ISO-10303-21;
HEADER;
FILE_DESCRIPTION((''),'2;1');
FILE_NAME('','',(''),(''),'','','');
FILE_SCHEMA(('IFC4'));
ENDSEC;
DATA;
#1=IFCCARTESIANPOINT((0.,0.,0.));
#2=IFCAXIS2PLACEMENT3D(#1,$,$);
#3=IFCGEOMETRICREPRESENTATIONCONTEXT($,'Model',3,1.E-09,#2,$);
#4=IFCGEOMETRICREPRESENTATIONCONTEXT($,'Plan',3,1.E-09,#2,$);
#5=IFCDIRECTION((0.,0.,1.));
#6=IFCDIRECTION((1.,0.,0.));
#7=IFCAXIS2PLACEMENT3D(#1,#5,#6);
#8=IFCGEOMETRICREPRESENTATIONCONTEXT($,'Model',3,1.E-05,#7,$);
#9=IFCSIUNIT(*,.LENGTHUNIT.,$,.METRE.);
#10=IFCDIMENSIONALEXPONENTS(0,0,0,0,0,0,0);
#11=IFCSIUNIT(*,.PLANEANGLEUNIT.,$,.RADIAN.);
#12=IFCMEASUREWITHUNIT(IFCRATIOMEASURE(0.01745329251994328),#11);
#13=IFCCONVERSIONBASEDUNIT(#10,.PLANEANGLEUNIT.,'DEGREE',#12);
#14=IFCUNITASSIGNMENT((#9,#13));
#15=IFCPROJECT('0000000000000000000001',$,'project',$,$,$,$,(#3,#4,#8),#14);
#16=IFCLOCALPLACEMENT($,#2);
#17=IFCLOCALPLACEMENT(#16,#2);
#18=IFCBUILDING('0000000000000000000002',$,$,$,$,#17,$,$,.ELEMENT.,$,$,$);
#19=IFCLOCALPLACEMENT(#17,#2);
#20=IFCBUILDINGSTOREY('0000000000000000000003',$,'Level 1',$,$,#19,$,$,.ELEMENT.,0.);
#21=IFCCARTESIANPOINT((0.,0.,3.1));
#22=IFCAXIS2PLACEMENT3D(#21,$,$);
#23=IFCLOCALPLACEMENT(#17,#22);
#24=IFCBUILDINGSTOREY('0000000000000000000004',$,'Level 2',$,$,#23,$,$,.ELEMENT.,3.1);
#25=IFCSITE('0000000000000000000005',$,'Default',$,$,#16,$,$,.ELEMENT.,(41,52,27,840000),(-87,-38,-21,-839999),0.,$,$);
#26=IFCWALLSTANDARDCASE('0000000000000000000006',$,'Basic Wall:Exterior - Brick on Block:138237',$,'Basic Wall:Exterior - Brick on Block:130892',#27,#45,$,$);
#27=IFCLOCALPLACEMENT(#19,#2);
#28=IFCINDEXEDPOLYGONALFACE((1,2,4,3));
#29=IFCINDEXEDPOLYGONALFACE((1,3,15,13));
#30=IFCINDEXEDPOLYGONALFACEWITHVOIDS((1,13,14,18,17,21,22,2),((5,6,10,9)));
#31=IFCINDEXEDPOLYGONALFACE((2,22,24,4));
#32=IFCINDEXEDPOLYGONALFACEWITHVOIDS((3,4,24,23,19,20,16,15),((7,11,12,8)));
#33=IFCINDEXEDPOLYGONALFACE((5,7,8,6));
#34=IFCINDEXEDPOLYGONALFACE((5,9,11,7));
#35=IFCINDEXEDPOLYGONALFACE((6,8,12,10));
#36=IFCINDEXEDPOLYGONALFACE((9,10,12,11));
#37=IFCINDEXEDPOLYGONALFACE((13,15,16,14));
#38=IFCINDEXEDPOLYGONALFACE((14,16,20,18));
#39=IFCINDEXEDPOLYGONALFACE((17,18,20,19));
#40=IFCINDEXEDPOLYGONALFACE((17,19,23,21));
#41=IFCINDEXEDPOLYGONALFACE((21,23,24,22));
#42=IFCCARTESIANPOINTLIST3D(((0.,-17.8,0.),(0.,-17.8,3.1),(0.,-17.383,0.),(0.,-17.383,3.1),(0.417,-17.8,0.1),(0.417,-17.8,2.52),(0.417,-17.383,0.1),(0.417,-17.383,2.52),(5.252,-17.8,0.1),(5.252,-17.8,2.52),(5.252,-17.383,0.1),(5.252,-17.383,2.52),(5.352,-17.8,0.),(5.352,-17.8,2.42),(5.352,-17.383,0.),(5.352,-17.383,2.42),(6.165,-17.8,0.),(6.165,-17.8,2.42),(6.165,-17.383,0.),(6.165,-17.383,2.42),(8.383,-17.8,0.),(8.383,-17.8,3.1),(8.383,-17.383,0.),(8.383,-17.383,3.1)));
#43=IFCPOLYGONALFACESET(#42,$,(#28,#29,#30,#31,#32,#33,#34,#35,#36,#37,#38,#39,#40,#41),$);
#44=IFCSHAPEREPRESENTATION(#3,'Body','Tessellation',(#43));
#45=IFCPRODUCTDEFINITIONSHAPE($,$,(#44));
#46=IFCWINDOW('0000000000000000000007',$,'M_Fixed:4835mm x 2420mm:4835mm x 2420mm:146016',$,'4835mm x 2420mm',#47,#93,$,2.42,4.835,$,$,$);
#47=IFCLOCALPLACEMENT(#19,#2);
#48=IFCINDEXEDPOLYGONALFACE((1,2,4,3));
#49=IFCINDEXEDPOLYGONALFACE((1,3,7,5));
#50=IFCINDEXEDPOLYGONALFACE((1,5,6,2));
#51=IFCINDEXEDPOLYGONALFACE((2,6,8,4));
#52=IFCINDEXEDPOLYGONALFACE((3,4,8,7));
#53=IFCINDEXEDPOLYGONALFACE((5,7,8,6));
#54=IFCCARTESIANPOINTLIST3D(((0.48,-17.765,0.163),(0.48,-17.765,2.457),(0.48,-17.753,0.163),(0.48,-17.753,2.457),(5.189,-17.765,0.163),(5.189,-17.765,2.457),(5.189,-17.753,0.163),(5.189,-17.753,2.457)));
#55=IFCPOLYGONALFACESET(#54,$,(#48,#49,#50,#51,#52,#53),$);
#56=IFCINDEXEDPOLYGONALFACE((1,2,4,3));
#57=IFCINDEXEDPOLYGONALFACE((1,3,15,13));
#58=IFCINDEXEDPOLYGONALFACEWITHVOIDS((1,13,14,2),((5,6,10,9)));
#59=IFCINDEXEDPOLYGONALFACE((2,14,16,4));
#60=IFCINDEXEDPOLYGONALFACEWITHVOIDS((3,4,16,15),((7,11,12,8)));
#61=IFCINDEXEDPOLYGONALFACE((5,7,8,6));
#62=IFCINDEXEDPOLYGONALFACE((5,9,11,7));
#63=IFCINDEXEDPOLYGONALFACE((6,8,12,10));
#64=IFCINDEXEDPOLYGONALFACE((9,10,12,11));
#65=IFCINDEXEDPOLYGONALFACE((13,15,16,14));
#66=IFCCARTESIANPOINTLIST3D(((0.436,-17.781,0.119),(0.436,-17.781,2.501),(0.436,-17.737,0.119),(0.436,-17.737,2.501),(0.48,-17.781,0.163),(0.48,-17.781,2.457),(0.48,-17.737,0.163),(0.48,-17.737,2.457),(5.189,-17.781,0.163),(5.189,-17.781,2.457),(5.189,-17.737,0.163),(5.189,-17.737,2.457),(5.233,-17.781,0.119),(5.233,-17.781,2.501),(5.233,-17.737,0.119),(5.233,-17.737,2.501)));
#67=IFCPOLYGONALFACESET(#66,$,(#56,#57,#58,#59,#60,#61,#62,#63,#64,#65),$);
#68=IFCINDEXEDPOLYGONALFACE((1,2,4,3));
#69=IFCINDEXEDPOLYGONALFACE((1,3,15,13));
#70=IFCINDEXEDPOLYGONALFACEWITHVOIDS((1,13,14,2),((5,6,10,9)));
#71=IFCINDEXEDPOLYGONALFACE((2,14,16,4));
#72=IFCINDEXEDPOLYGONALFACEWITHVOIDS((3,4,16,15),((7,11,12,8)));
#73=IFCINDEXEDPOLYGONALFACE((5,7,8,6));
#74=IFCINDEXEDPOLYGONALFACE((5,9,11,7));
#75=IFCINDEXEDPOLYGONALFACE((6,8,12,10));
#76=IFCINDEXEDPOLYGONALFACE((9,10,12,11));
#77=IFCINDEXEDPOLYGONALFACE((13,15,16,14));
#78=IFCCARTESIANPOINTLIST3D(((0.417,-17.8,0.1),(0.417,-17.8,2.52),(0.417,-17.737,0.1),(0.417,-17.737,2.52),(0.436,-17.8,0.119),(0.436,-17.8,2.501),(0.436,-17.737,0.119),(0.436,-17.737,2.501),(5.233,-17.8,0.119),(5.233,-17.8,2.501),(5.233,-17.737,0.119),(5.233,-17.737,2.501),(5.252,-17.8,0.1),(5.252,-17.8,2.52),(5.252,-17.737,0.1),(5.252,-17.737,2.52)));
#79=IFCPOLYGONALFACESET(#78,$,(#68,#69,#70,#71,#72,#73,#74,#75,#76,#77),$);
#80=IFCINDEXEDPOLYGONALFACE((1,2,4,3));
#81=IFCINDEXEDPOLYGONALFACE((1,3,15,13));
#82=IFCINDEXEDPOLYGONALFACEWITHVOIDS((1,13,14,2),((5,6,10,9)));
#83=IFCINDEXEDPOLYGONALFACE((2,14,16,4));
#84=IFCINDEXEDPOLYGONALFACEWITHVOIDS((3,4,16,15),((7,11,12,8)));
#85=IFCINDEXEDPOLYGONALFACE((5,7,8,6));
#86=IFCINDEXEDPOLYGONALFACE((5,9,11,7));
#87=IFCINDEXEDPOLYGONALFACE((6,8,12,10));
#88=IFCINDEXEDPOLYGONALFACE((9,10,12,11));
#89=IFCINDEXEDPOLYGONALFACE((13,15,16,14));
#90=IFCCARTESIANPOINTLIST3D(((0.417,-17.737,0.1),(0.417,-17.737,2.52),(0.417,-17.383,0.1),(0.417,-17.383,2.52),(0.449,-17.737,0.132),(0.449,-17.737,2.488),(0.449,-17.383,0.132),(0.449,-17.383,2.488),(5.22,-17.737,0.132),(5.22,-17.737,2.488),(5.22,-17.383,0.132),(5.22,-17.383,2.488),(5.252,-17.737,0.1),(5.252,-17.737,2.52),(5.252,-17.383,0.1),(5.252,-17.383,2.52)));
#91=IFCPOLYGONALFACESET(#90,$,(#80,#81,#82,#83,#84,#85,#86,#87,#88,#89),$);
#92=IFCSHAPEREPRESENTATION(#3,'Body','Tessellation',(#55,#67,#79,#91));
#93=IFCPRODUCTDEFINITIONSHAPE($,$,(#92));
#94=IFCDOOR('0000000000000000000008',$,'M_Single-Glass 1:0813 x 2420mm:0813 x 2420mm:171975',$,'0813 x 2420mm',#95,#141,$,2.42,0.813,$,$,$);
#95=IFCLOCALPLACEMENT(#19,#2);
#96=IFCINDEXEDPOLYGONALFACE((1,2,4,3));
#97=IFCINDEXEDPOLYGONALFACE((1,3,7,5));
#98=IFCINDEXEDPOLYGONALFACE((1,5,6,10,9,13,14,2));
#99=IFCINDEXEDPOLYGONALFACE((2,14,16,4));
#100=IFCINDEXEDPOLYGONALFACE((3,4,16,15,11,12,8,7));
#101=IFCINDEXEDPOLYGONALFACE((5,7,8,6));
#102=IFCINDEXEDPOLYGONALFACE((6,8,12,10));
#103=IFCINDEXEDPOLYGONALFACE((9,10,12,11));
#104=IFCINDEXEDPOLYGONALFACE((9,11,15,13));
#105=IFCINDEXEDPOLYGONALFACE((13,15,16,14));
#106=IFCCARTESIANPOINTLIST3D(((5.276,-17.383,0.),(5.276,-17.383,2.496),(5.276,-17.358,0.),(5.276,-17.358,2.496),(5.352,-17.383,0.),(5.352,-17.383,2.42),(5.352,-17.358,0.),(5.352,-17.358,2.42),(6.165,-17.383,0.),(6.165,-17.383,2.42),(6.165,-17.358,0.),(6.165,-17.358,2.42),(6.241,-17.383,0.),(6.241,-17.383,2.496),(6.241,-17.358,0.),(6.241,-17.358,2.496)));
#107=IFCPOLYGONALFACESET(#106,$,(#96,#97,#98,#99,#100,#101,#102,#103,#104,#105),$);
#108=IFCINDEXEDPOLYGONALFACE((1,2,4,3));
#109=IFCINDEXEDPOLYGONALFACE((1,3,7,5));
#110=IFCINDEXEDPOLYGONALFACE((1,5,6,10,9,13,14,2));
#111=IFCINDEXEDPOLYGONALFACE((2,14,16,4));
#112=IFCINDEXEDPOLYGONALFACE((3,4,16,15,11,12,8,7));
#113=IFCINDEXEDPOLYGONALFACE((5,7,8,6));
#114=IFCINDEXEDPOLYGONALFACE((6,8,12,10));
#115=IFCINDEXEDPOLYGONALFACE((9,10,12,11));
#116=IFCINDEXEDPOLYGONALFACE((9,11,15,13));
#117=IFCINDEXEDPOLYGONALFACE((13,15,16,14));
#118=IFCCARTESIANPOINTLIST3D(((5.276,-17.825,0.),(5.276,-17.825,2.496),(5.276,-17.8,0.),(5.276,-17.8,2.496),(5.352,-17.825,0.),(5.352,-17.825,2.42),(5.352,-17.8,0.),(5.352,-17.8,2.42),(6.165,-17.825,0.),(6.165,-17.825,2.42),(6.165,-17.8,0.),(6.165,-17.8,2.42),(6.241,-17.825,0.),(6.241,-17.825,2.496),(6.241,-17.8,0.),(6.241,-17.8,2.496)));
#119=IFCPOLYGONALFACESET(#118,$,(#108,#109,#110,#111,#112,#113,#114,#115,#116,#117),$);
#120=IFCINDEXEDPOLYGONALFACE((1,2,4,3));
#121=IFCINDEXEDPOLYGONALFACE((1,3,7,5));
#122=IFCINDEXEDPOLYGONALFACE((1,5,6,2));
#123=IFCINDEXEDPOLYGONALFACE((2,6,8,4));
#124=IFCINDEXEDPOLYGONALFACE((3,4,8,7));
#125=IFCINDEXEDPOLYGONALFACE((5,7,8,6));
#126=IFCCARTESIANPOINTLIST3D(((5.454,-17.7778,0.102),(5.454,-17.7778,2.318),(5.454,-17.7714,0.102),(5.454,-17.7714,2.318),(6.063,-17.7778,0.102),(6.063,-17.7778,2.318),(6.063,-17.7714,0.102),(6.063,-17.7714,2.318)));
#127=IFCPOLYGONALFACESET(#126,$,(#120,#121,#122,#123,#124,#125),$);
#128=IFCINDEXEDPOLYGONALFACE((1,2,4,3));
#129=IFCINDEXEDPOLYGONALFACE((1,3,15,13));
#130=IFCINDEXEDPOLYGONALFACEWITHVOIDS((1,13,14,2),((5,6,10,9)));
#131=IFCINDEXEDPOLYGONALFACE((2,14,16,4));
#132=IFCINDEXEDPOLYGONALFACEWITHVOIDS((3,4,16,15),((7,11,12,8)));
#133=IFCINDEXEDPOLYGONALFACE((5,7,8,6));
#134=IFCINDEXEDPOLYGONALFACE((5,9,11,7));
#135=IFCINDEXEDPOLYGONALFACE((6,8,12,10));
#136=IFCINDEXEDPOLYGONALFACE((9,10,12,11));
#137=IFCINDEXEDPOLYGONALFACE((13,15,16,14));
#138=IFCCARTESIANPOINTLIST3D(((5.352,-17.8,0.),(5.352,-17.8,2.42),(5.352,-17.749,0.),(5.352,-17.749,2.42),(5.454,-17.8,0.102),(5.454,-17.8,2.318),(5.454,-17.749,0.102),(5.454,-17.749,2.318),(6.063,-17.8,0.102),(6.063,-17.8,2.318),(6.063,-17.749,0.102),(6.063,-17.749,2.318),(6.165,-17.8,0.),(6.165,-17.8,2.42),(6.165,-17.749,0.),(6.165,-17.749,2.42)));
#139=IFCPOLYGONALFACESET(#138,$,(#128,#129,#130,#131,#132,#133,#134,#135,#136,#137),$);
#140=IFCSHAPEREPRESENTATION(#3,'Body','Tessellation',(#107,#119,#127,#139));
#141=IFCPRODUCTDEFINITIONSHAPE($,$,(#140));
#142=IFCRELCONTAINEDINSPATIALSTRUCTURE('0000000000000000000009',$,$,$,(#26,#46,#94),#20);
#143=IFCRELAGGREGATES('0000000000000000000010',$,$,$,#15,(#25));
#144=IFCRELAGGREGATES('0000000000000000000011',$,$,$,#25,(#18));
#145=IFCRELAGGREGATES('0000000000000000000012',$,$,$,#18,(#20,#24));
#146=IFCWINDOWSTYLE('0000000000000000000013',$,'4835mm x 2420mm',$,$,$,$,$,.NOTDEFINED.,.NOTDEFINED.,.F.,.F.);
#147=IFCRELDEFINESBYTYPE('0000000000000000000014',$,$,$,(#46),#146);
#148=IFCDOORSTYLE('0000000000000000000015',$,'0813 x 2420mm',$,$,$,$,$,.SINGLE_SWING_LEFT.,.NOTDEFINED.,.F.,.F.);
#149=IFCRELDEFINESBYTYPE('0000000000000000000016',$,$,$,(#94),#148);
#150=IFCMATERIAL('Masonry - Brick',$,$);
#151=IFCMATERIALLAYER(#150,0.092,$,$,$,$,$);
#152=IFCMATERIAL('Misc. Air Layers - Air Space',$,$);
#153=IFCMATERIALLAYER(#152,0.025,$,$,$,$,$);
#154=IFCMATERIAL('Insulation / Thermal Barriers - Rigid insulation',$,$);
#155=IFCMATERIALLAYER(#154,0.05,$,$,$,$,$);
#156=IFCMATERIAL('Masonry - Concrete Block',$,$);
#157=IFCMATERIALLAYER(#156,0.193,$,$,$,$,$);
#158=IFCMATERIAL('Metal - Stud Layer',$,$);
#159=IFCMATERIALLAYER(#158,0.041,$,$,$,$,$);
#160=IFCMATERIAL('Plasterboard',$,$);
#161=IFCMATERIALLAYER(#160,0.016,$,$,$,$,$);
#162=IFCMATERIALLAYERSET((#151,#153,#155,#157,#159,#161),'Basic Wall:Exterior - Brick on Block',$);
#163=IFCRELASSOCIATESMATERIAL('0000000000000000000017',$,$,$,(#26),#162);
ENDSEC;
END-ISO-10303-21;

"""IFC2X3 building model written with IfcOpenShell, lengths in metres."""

from ifc_helpers import new_model, entity, si_unit, converted_unit, frame, frame_2d, origin, origin_with_axes, origin_2d_with_axis, place, context, project, spatial, polyline, rectangle, outline, extrude, source, transform, mapped, material, layer, layer_set, layer_usage, type_object, type_shapes, element, fill, save


model = new_model("IFC2X3")

# Units and contexts
model_context_1 = context("Model", 3, precision=1e-09, world=origin())
plan_context = context("Plan", 3, precision=1e-09, world=origin())
model_context_2 = context("Model", 3, precision=1e-05, world=origin_with_axes())
ifc_project = project(units=[si_unit("LENGTHUNIT", "METRE"), converted_unit("PLANEANGLEUNIT", "DEGREE", entity("IfcRatioMeasure", 0.01745329251994328), si_unit("PLANEANGLEUNIT", "RADIAN"), dimensions=[0, 0, 0, 0, 0, 0, 0])], contexts=[model_context_1, plan_context, model_context_2])

# Site, building, storey
site_placement = place(None, origin())
site = spatial("IfcSite", under=ifc_project, at=site_placement, Name="Default", CompositionType="ELEMENT", RefLatitude=(41, 52, 27, 840000), RefLongitude=(-87, -38, -21, -839999), RefElevation=0.0)
building_placement = place(site_placement, origin())
building = spatial("IfcBuilding", under=site, at=building_placement, CompositionType="ELEMENT")
storey_1_placement = place(building_placement, origin())
storey_1 = spatial("IfcBuildingStorey", under=building, at=storey_1_placement, Name="Level 1", CompositionType="ELEMENT", Elevation=0.0)

# Wall, openings, window, door
ifc_material_1 = material(Name="Masonry - Brick")
ifc_layer_1 = layer(ifc_material_1, 0.092)
ifc_material_2 = material(Name="Misc. Air Layers - Air Space")
ifc_layer_2 = layer(ifc_material_2, 0.025)
ifc_material_3 = material(Name="Insulation / Thermal Barriers - Rigid insulation")
ifc_layer_3 = layer(ifc_material_3, 0.05)
ifc_material_4 = material(Name="Masonry - Concrete Block")
ifc_layer_4 = layer(ifc_material_4, 0.193)
ifc_material_5 = material(Name="Metal - Stud Layer")
ifc_layer_5 = layer(ifc_material_5, 0.041)
ifc_material_6 = material(Name="Plasterboard")
ifc_layer_6 = layer(ifc_material_6, 0.016)
ifc_layer_set_1 = layer_set([ifc_layer_1, ifc_layer_2, ifc_layer_3, ifc_layer_4, ifc_layer_5, ifc_layer_6], Name="Basic Wall:Exterior - Brick on Block")
ifc_layer_usage_1 = layer_usage(ifc_layer_set_1, "AXIS2", "NEGATIVE", 0.2085)
wall_1_placement = place(storey_1_placement, frame((8.383, -17.5915, 0.0), z_axis=(0.0, 0.0, 1.0), x_axis=(-1.0, 0.0, 0.0)))
wall_1 = element("IfcWallStandardCase", 1, at=wall_1_placement, inside=storey_1, material=ifc_layer_usage_1, Name="Basic Wall:Exterior - Brick on Block:138237", ObjectType="Basic Wall:Exterior - Brick on Block:130892", context=model_context_1, shape_type="SweptSolid", body=[
    extrude(rectangle(XDim=8.383, YDim=0.417, at=frame_2d((4.1915, 0.0), x_axis=(-1.0, 0.0))), origin(), (0.0, 0.0, 1.0), 3.1),
])
opening_1_placement = place(wall_1_placement, frame((3.131, -0.2085, 0.1)))
opening_1 = element("IfcOpeningElement", 2, at=opening_1_placement, cuts=wall_1, ObjectType="Opening", context=model_context_1, shape_type="SweptSolid", body=[
    extrude(rectangle(XDim=2.42, YDim=4.835, at=frame_2d((1.21, 2.4175), x_axis=(1.0, 0.0))), frame((0.0, 0.0, 0.0), z_axis=(0.0, 1.0, 0.0), x_axis=(0.0, 0.0, 1.0)), (0.0, 0.0, 1.0), 0.417),
])
opening_2_placement = place(wall_1_placement, frame((2.218, -0.2085, 0.0)))
opening_2 = element("IfcOpeningElement", 3, at=opening_2_placement, cuts=wall_1, ObjectType="Opening", context=model_context_1, shape_type="SweptSolid", body=[
    extrude(rectangle(XDim=0.813, YDim=2.42, at=frame_2d((1.21, 0.4065), x_axis=(0.0, -1.0))), frame((0.0, 0.0, 0.0), z_axis=(0.0, 1.0, 0.0), x_axis=(0.0, 0.0, 1.0)), (0.0, 0.0, 1.0), 0.417),
])
window_style_1 = type_object("IfcWindowStyle", Name="4835mm x 2420mm", ConstructionType="NOTDEFINED", OperationType="NOTDEFINED", ParameterTakesPrecedence=False, Sizeable=False)
shared_shape_1 = source(origin(), model_context_1, "Body", "SweptSolid", [
    extrude(rectangle(XDim=0.012, YDim=4.709, at=origin_2d_with_axis()), frame((2.4175, 0.376, 0.063), z_axis=(0.0, 0.0, 1.0), x_axis=(0.0, -1.0, 0.0)), (0.0, 0.0, 1.0), 2.294),
    extrude(outline(polyline([(-2.3985, -1.191), (2.3985, -1.191), (2.3985, 1.191), (-2.3985, 1.191), (-2.3985, -1.191)]), holes=[polyline([(-2.3545, -1.147), (-2.3545, 1.147), (2.3545, 1.147), (2.3545, -1.147), (-2.3545, -1.147)])]), frame((2.4175, 0.354, 1.21), z_axis=(0.0, 1.0, 0.0), x_axis=(1.0, 0.0, 0.0)), (0.0, 0.0, 1.0), 0.044),
    extrude(outline(polyline([(-2.4175, -1.21), (2.4175, -1.21), (2.4175, 1.21), (-2.4175, 1.21), (-2.4175, -1.21)]), holes=[polyline([(-2.3985, -1.191), (-2.3985, 1.191), (2.3985, 1.191), (2.3985, -1.191), (-2.3985, -1.191)])]), frame((2.4175, 0.354, 1.21), z_axis=(0.0, 1.0, 0.0), x_axis=(1.0, 0.0, 0.0)), (0.0, 0.0, 1.0), 0.063),
    extrude(outline(polyline([(-2.4175, -1.21), (2.4175, -1.21), (2.4175, 1.21), (-2.4175, 1.21), (-2.4175, -1.21)]), holes=[polyline([(-2.3855, -1.178), (-2.3855, 1.178), (2.3855, 1.178), (2.3855, -1.178), (-2.3855, -1.178)])]), frame((2.4175, 0.0, 1.21), z_axis=(0.0, 1.0, 0.0), x_axis=(1.0, 0.0, 0.0)), (0.0, 0.0, 1.0), 0.354),
])
type_shapes(window_style_1, [shared_shape_1])
window_1_placement = place(opening_1_placement, origin())
window_1 = element("IfcWindow", 4, at=window_1_placement, inside=storey_1, type_object=window_style_1, Name="M_Fixed:4835mm x 2420mm:4835mm x 2420mm:146016", ObjectType="4835mm x 2420mm", OverallHeight=2.42, OverallWidth=4.835, context=model_context_1, shape_type="MappedRepresentation", body=[
    mapped(shared_shape_1, transform((0.0, 0.0, 0.0), scale=1.0)),
])
fill(opening_1, window_1)
door_style_1 = type_object("IfcDoorStyle", Name="0813 x 2420mm", ConstructionType="NOTDEFINED", OperationType="SINGLE_SWING_LEFT", ParameterTakesPrecedence=False, Sizeable=False)
shared_shape_2 = source(origin(), model_context_1, "Body", "SweptSolid", [
    extrude(outline(polyline([(-0.4065, -1.191), (-0.4065, 1.229), (-0.4825, 1.229), (-0.4825, -1.267), (0.4825, -1.267), (0.4825, 1.229), (0.4065, 1.229), (0.4065, -1.191), (-0.4065, -1.191)])), frame((0.4065, 0.0, 1.229), z_axis=(0.0, 1.0, 0.0), x_axis=(1.0, 0.0, 0.0)), (0.0, 0.0, -1.0), 0.025),
    extrude(outline(polyline([(-0.4065, -1.191), (-0.4065, 1.229), (-0.4825, 1.229), (-0.4825, -1.267), (0.4825, -1.267), (0.4825, 1.229), (0.4065, 1.229), (0.4065, -1.191), (-0.4065, -1.191)])), frame((0.4065, 0.442, 1.229), z_axis=(0.0, 1.0, 0.0), x_axis=(1.0, 0.0, 0.0)), (0.0, 0.0, -1.0), 0.025),
    extrude(rectangle(XDim=0.609, YDim=0.0064, at=origin_2d_with_axis()), frame((0.4065, 0.3916, 0.102)), (0.0, 0.0, 1.0), 2.216),
    extrude(outline(polyline([(-1.21, -0.4065), (1.21, -0.4065), (1.21, 0.4065), (-1.21, 0.4065), (-1.21, -0.4065)]), holes=[polyline([(-1.108, 0.3045), (1.108, 0.3045), (1.108, -0.3045), (-1.108, -0.3045), (-1.108, 0.3045)])]), frame((0.4065, 0.417, 1.21), z_axis=(0.0, -1.0, 0.0), x_axis=(0.0, 0.0, -1.0)), (0.0, 0.0, 1.0), 0.051),
])
type_shapes(door_style_1, [shared_shape_2])
door_1_placement = place(opening_2_placement, origin())
door_1 = element("IfcDoor", 5, at=door_1_placement, inside=storey_1, type_object=door_style_1, Name="M_Single-Glass 1:0813 x 2420mm:0813 x 2420mm:171975", ObjectType="0813 x 2420mm", OverallHeight=2.42, OverallWidth=0.813, context=model_context_1, shape_type="MappedRepresentation", body=[
    mapped(shared_shape_2, transform((0.0, 0.0, 0.0), scale=1.0)),
])
fill(opening_2, door_1)

# Shared definitions
storey_2_placement = place(building_placement, frame((0.0, 0.0, 3.1)))
storey_2 = spatial("IfcBuildingStorey", under=building, at=storey_2_placement, Name="Level 2", CompositionType="ELEMENT", Elevation=3.1)

save(model, "model.ifc")
